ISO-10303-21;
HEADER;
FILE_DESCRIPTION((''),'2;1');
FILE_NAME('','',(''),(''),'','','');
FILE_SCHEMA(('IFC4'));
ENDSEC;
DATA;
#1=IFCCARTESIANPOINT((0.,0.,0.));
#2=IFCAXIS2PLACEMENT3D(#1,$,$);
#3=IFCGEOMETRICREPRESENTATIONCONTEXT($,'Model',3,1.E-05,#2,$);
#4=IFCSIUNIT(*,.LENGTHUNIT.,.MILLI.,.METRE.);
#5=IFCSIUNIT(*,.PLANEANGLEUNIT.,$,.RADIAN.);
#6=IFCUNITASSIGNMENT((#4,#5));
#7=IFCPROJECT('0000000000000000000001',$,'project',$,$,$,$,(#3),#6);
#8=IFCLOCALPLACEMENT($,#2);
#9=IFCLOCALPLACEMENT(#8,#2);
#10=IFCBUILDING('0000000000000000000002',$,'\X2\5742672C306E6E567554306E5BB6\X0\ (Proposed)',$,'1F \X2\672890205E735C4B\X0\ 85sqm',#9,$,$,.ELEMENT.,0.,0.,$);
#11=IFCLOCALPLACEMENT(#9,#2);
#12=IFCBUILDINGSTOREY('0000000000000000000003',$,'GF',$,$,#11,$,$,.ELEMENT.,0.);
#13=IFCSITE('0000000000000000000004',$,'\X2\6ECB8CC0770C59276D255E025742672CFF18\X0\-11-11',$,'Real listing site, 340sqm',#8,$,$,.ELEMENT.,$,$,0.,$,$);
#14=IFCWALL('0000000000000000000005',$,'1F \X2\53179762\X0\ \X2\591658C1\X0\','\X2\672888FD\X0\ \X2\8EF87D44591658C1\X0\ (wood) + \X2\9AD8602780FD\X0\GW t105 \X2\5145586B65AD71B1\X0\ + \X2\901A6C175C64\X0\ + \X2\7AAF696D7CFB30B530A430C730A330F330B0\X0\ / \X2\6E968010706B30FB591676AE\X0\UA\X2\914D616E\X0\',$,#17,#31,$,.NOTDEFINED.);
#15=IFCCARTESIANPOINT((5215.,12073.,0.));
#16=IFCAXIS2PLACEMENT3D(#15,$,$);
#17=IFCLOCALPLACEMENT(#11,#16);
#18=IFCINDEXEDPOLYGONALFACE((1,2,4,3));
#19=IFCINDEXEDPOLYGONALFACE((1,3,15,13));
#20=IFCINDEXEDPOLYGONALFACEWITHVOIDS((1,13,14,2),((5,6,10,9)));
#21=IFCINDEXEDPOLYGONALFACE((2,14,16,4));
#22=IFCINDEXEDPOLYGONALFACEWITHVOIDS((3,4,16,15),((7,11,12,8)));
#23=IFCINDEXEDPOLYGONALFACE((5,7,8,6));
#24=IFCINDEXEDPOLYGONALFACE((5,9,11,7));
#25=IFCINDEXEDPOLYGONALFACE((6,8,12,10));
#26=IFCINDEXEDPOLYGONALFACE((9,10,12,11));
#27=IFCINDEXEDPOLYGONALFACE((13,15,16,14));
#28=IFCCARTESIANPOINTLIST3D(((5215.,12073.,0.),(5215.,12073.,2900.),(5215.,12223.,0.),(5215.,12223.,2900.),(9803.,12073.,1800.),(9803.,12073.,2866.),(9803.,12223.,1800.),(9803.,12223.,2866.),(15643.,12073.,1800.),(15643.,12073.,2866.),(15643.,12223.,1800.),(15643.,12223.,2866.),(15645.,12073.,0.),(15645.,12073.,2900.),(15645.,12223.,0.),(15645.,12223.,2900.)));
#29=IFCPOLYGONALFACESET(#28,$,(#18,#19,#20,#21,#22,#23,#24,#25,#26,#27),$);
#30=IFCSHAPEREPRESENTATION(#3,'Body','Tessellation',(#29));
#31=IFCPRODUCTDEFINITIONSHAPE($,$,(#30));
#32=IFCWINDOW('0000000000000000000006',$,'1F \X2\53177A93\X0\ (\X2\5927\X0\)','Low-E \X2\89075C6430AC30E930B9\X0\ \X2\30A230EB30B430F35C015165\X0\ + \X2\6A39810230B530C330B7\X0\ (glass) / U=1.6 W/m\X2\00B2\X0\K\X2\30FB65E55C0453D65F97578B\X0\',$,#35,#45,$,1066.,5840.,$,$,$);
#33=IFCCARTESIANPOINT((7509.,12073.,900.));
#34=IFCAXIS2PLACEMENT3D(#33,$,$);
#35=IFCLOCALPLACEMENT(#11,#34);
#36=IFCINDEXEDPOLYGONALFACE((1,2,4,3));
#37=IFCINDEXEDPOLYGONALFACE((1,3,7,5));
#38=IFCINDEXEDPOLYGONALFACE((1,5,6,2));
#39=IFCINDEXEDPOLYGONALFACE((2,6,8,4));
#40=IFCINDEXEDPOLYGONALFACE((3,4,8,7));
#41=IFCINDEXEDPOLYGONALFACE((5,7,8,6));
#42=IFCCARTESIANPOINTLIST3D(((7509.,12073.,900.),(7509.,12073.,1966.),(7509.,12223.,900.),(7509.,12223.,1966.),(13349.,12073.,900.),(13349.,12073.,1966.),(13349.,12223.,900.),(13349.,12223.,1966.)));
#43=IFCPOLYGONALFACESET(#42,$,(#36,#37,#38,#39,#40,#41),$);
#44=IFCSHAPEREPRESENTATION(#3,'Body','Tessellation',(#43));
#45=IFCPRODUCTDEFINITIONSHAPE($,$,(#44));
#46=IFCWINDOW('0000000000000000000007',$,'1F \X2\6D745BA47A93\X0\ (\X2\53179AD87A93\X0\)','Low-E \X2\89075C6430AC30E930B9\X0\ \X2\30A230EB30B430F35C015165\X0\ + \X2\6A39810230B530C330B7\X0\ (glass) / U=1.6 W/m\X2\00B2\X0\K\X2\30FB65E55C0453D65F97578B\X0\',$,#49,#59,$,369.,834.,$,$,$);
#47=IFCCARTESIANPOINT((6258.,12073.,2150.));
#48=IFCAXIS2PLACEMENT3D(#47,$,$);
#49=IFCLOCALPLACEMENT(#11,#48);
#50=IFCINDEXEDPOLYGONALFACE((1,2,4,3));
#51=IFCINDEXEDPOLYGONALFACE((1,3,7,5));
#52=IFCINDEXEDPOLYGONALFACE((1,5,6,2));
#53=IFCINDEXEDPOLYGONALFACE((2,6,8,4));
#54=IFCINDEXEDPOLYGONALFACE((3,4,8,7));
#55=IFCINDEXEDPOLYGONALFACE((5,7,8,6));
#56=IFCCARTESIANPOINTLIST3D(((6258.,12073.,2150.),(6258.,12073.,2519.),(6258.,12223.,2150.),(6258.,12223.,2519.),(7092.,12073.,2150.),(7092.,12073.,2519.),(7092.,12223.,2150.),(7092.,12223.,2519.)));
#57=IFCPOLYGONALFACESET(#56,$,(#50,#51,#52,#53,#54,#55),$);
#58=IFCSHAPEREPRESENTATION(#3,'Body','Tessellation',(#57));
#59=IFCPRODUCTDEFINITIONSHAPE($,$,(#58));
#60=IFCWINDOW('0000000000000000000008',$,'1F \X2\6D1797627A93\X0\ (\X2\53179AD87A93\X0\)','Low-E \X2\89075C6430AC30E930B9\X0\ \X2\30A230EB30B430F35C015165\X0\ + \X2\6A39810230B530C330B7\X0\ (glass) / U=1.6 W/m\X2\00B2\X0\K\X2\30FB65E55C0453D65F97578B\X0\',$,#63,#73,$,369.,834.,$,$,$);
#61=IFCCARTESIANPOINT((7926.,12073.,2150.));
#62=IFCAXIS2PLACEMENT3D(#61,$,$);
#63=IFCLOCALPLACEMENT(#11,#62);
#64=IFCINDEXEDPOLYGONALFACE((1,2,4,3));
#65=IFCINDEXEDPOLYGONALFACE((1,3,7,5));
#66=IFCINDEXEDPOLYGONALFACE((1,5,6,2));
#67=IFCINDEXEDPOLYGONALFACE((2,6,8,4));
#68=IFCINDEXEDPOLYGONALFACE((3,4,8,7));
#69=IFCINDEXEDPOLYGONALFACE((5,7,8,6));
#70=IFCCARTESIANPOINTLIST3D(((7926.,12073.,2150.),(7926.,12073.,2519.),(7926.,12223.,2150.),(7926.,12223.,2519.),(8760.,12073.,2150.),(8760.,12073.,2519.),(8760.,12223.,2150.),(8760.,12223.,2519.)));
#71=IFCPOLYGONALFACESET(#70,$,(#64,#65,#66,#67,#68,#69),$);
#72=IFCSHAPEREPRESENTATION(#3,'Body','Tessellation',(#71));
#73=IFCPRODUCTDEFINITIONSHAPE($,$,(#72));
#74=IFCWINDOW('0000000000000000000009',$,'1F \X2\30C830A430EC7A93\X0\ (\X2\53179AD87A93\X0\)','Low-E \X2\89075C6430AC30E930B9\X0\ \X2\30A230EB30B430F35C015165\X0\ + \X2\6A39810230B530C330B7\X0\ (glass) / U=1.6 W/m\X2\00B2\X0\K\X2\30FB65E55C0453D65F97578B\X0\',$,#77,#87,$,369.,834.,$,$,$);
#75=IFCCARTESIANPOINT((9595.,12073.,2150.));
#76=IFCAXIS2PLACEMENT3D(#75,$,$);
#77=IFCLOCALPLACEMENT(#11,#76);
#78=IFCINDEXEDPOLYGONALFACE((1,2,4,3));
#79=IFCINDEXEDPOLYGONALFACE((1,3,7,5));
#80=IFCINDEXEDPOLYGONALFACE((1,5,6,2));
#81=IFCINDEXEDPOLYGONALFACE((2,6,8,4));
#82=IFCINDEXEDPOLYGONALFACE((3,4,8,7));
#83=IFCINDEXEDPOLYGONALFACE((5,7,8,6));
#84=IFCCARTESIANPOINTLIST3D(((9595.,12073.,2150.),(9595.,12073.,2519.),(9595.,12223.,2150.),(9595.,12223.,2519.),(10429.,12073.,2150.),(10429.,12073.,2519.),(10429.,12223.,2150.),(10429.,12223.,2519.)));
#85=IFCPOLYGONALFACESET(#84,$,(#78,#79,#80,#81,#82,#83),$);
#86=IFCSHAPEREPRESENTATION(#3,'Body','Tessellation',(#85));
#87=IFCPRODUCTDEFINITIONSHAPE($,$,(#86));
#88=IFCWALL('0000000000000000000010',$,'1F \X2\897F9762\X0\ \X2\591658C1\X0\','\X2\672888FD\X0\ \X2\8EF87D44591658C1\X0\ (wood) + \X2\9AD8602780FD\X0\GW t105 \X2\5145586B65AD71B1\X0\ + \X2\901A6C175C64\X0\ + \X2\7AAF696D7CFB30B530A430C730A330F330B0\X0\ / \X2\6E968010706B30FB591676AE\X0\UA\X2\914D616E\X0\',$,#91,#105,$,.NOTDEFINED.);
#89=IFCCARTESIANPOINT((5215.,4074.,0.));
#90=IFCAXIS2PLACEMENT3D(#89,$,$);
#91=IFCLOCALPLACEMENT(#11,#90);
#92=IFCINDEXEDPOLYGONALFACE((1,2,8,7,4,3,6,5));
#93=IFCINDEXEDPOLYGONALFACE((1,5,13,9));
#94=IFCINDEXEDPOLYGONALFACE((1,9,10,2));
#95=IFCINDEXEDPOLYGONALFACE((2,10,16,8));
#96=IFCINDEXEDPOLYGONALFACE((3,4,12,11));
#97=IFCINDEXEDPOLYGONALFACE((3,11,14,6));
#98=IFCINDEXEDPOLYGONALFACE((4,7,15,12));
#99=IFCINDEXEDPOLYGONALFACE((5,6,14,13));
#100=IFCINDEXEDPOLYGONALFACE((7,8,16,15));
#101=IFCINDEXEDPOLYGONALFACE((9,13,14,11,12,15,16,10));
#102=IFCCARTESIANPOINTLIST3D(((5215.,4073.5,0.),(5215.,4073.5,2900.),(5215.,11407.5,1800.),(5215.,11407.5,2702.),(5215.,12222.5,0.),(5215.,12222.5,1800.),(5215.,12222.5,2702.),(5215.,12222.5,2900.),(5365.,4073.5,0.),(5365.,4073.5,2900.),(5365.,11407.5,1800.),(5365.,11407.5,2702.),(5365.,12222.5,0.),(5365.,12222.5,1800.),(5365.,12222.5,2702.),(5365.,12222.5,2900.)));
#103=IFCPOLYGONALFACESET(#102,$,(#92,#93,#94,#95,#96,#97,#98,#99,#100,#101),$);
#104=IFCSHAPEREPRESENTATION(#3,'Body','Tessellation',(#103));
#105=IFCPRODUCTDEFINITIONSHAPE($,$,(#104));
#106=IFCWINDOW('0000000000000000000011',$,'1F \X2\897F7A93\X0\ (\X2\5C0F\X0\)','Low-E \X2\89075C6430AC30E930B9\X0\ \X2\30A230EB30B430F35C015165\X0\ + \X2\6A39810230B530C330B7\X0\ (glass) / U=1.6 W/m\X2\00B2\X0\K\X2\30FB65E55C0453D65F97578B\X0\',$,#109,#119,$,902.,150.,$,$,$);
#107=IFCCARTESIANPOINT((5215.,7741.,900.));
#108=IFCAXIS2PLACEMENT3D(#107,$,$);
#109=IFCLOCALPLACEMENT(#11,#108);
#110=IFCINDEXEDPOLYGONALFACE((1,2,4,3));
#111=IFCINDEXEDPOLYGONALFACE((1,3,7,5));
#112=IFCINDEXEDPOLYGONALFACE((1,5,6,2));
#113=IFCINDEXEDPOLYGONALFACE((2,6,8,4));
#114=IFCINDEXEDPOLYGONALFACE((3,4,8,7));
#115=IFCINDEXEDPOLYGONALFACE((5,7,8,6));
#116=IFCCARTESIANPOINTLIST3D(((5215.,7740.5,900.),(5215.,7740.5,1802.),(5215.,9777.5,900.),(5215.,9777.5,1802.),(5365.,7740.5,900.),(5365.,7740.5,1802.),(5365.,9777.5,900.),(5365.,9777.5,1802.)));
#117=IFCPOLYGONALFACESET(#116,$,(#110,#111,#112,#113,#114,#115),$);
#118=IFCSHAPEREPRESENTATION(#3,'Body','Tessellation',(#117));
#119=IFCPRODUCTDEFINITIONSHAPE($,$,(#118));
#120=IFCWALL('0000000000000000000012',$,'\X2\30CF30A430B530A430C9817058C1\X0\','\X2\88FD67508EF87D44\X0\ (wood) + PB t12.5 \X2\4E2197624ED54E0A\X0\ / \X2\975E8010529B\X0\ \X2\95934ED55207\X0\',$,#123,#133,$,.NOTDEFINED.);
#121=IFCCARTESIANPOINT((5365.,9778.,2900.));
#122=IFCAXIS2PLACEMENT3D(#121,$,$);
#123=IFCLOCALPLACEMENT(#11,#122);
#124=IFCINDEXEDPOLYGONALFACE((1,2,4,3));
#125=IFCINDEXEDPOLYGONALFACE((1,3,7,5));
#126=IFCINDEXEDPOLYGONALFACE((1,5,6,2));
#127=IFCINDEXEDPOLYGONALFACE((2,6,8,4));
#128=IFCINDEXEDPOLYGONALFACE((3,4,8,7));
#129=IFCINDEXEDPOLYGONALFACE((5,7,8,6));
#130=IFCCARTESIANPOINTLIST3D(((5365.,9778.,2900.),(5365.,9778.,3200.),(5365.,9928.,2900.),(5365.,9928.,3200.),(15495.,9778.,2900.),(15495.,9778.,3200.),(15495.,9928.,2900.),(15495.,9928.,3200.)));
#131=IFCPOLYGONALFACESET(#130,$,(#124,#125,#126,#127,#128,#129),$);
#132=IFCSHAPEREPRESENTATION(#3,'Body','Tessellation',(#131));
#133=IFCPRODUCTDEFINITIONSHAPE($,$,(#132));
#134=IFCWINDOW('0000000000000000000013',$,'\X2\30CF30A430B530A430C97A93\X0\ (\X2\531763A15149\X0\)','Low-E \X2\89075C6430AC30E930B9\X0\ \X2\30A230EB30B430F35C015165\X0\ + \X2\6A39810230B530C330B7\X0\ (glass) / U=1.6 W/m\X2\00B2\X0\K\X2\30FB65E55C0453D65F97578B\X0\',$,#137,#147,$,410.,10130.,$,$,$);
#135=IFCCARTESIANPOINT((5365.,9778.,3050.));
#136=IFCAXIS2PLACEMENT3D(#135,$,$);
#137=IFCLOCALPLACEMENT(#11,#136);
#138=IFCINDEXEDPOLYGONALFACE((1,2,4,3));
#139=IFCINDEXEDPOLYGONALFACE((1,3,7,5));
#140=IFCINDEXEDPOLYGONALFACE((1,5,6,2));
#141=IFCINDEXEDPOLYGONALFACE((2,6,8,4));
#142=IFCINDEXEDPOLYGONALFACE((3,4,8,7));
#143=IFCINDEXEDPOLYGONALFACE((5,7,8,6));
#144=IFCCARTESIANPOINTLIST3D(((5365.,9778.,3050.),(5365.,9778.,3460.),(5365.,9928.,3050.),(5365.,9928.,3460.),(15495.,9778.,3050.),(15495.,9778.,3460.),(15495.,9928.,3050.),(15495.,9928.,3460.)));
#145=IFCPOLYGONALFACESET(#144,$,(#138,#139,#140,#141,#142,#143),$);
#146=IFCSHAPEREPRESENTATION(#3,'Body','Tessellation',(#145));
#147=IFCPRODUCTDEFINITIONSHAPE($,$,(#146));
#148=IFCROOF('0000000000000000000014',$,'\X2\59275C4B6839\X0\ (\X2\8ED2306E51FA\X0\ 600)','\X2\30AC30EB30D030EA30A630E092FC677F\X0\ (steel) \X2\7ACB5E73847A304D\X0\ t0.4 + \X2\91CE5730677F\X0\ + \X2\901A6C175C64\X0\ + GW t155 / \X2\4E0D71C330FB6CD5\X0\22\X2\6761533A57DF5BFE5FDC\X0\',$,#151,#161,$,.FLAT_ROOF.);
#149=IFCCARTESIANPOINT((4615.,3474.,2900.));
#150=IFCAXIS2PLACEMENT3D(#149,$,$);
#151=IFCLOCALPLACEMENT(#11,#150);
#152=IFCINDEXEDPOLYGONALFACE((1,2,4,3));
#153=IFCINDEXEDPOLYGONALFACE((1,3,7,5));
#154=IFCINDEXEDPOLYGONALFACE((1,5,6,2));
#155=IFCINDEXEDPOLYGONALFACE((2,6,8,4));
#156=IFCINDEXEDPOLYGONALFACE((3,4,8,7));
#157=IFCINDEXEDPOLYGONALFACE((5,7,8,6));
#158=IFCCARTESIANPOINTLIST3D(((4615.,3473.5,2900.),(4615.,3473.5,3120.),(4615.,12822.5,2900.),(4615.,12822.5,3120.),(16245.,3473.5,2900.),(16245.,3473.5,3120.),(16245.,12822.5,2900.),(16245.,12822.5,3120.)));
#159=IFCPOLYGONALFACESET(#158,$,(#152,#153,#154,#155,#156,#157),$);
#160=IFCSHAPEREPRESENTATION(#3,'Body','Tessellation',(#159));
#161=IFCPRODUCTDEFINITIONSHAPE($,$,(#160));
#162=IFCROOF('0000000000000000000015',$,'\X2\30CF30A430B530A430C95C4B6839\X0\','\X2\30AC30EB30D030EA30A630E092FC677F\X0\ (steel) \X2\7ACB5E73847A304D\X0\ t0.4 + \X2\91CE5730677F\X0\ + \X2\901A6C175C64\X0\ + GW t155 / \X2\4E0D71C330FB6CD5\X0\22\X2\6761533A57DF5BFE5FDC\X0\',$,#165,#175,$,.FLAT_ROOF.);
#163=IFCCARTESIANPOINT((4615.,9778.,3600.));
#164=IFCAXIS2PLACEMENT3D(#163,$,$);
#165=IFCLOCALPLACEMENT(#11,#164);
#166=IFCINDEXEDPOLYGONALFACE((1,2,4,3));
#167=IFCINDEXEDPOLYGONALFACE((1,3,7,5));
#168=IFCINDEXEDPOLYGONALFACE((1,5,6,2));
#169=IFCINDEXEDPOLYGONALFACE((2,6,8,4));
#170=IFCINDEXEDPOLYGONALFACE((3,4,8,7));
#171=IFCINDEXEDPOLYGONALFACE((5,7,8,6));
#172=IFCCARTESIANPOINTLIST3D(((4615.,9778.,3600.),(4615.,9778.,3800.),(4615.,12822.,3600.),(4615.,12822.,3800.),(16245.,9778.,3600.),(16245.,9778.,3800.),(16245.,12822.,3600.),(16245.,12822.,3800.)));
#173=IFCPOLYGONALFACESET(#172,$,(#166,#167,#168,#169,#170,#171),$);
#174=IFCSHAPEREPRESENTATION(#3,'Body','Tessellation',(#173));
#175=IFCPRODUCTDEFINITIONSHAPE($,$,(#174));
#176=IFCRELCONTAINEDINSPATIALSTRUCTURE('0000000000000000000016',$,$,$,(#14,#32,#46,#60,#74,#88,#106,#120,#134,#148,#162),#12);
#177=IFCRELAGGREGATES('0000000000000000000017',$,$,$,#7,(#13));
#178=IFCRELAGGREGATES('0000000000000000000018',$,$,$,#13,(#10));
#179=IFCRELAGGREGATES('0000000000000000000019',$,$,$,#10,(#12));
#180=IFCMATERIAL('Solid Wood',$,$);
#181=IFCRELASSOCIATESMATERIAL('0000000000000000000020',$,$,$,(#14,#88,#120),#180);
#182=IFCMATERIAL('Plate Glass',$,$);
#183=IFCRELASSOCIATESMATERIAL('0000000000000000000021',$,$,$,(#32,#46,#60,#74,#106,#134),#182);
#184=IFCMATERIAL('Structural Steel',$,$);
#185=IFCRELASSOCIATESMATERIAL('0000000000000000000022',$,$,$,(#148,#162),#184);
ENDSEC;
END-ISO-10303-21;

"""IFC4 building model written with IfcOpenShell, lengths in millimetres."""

from ifc_helpers import new_model, si_unit, frame, frame_2d, origin, place, context, project, spatial, rectangle, extrude, material, element, fill, save


model = new_model("IFC4")

# Units and contexts
model_context = context("Model", 3, precision=1e-05, world=origin())
ifc_project = project(units=[si_unit("LENGTHUNIT", "METRE", prefix="MILLI"), si_unit("PLANEANGLEUNIT", "RADIAN")], contexts=[model_context])

# Site, building, storey
site_placement = place(None, origin())
site = spatial("IfcSite", under=ifc_project, at=site_placement, Name="滋賀県大津市坂本８-11-11", ObjectType="Real listing site, 340sqm", CompositionType="ELEMENT", RefElevation=0.0)
building_placement = place(site_placement, origin())
building = spatial("IfcBuilding", under=site, at=building_placement, Name="坂本の湖畔の家 (Proposed)", ObjectType="1F 木造平屋 85sqm", CompositionType="ELEMENT", ElevationOfRefHeight=0.0, ElevationOfTerrain=0.0)
storey_placement = place(building_placement, origin())
storey = spatial("IfcBuildingStorey", under=building, at=storey_placement, Name="GF", CompositionType="ELEMENT", Elevation=0.0)

# Shared definitions
ifc_material_1 = material(Name="Solid Wood")

# Shared definitions
ifc_material_2 = material(Name="Plate Glass")

# Wall, openings, windows
wall_1_placement = place(storey_placement, frame((5215.0, 12073.0, 0.0)))
wall_1 = element("IfcWall", 1, at=wall_1_placement, inside=storey, material=ifc_material_1, Name="1F 北面 外壁", Description="木製 軸組外壁 (wood) + 高性能GW t105 充填断熱 + 通気層 + 窯業系サイディング / 準耐火・外皮UA配慮", PredefinedType="NOTDEFINED", context=model_context, shape_type="SweptSolid", body=[
    extrude(rectangle(XDim=10430.0, YDim=150.0, at=frame_2d((5215.0, 75.0))), frame((5215.0, 12073.0, 0.0)), (0.0, 0.0, 1.0), 2900.0),
])
opening_1_placement = place(storey_placement, frame((7509.0, 12073.0, 900.0)))
opening_1 = element("IfcOpeningElement", 2, at=opening_1_placement, cuts=wall_1, PredefinedType="NOTDEFINED", context=model_context, shape_type="SweptSolid", body=[
    extrude(rectangle(XDim=5840.0, YDim=150.0, at=frame_2d((2920.0, 75.0))), frame((7509.0, 12073.0, 900.0)), (0.0, 0.0, 1.0), 1066.0),
])
opening_2_placement = place(storey_placement, frame((6258.0, 12073.0, 2150.0)))
opening_2 = element("IfcOpeningElement", 3, at=opening_2_placement, cuts=wall_1, PredefinedType="NOTDEFINED", context=model_context, shape_type="SweptSolid", body=[
    extrude(rectangle(XDim=834.0, YDim=150.0, at=frame_2d((417.0, 75.0))), frame((6258.0, 12073.0, 2150.0)), (0.0, 0.0, 1.0), 369.0),
])
opening_3_placement = place(storey_placement, frame((7926.0, 12073.0, 2150.0)))
opening_3 = element("IfcOpeningElement", 4, at=opening_3_placement, cuts=wall_1, PredefinedType="NOTDEFINED", context=model_context, shape_type="SweptSolid", body=[
    extrude(rectangle(XDim=834.0, YDim=150.0, at=frame_2d((417.0, 75.0))), frame((7926.0, 12073.0, 2150.0)), (0.0, 0.0, 1.0), 369.0),
])
opening_4_placement = place(storey_placement, frame((9595.0, 12073.0, 2150.0)))
opening_4 = element("IfcOpeningElement", 5, at=opening_4_placement, cuts=wall_1, PredefinedType="NOTDEFINED", context=model_context, shape_type="SweptSolid", body=[
    extrude(rectangle(XDim=834.0, YDim=150.0, at=frame_2d((417.0, 75.0))), frame((9595.0, 12073.0, 2150.0)), (0.0, 0.0, 1.0), 369.0),
])
window_1_placement = place(storey_placement, frame((7509.0, 12073.0, 900.0)))
window_1 = element("IfcWindow", 6, at=window_1_placement, inside=storey, material=ifc_material_2, Name="1F 北窓 (大)", Description="Low-E 複層ガラス アルゴン封入 + 樹脂サッシ (glass) / U=1.6 W/m²K・日射取得型", OverallHeight=1066.0, OverallWidth=5840.0, context=model_context, shape_type="SweptSolid", body=[
    extrude(rectangle(XDim=5840.0, YDim=150.0, at=frame_2d((2920.0, 75.0))), frame((7509.0, 12073.0, 900.0)), (0.0, 0.0, 1.0), 1066.0),
])
fill(opening_1, window_1)
window_2_placement = place(storey_placement, frame((6258.0, 12073.0, 2150.0)))
window_2 = element("IfcWindow", 7, at=window_2_placement, inside=storey, material=ifc_material_2, Name="1F 浴室窓 (北高窓)", Description="Low-E 複層ガラス アルゴン封入 + 樹脂サッシ (glass) / U=1.6 W/m²K・日射取得型", OverallHeight=369.0, OverallWidth=834.0, context=model_context, shape_type="SweptSolid", body=[
    extrude(rectangle(XDim=834.0, YDim=150.0, at=frame_2d((417.0, 75.0))), frame((6258.0, 12073.0, 2150.0)), (0.0, 0.0, 1.0), 369.0),
])
fill(opening_2, window_2)
window_3_placement = place(storey_placement, frame((7926.0, 12073.0, 2150.0)))
window_3 = element("IfcWindow", 8, at=window_3_placement, inside=storey, material=ifc_material_2, Name="1F 洗面窓 (北高窓)", Description="Low-E 複層ガラス アルゴン封入 + 樹脂サッシ (glass) / U=1.6 W/m²K・日射取得型", OverallHeight=369.0, OverallWidth=834.0, context=model_context, shape_type="SweptSolid", body=[
    extrude(rectangle(XDim=834.0, YDim=150.0, at=frame_2d((417.0, 75.0))), frame((7926.0, 12073.0, 2150.0)), (0.0, 0.0, 1.0), 369.0),
])
fill(opening_3, window_3)
window_4_placement = place(storey_placement, frame((9595.0, 12073.0, 2150.0)))
window_4 = element("IfcWindow", 9, at=window_4_placement, inside=storey, material=ifc_material_2, Name="1F トイレ窓 (北高窓)", Description="Low-E 複層ガラス アルゴン封入 + 樹脂サッシ (glass) / U=1.6 W/m²K・日射取得型", OverallHeight=369.0, OverallWidth=834.0, context=model_context, shape_type="SweptSolid", body=[
    extrude(rectangle(XDim=834.0, YDim=150.0, at=frame_2d((417.0, 75.0))), frame((9595.0, 12073.0, 2150.0)), (0.0, 0.0, 1.0), 369.0),
])
fill(opening_4, window_4)

# Wall, opening, window
wall_2_placement = place(storey_placement, frame((5215.0, 4074.0, 0.0)))
wall_2 = element("IfcWall", 10, at=wall_2_placement, inside=storey, material=ifc_material_1, Name="1F 西面 外壁", Description="木製 軸組外壁 (wood) + 高性能GW t105 充填断熱 + 通気層 + 窯業系サイディング / 準耐火・外皮UA配慮", PredefinedType="NOTDEFINED", context=model_context, shape_type="SweptSolid", body=[
    extrude(rectangle(XDim=150.0, YDim=8149.0, at=frame_2d((75.0, 4074.0))), frame((5215.0, 4074.0, 0.0)), (0.0, 0.0, 1.0), 2900.0),
])
opening_5_placement = place(storey_placement, frame((5215.0, 7741.0, 900.0)))
opening_5 = element("IfcOpeningElement", 11, at=opening_5_placement, cuts=wall_2, PredefinedType="NOTDEFINED", context=model_context, shape_type="SweptSolid", body=[
    extrude(rectangle(XDim=150.0, YDim=2037.0, at=frame_2d((75.0, 1018.0))), frame((5215.0, 7741.0, 900.0)), (0.0, 0.0, 1.0), 902.0),
])
window_5_placement = place(storey_placement, frame((5215.0, 7741.0, 900.0)))
window_5 = element("IfcWindow", 12, at=window_5_placement, inside=storey, material=ifc_material_2, Name="1F 西窓 (小)", Description="Low-E 複層ガラス アルゴン封入 + 樹脂サッシ (glass) / U=1.6 W/m²K・日射取得型", OverallHeight=902.0, OverallWidth=150.0, context=model_context, shape_type="SweptSolid", body=[
    extrude(rectangle(XDim=150.0, YDim=2037.0, at=frame_2d((75.0, 1018.0))), frame((5215.0, 7741.0, 900.0)), (0.0, 0.0, 1.0), 902.0),
])
fill(opening_5, window_5)

# Wall, opening, window
wall_3_placement = place(storey_placement, frame((5365.0, 9778.0, 2900.0)))
wall_3 = element("IfcWall", 13, at=wall_3_placement, inside=storey, material=ifc_material_1, Name="ハイサイド腰壁", Description="製材軸組 (wood) + PB t12.5 両面仕上 / 非耐力 間仕切", PredefinedType="NOTDEFINED", context=model_context, shape_type="SweptSolid", body=[
    extrude(rectangle(XDim=10130.0, YDim=150.0, at=frame_2d((5065.0, 75.0))), frame((5365.0, 9778.0, 2900.0)), (0.0, 0.0, 1.0), 700.0),
])
opening_6_placement = place(storey_placement, frame((5365.0, 9778.0, 3050.0)))
opening_6 = element("IfcOpeningElement", 14, at=opening_6_placement, cuts=wall_3, PredefinedType="NOTDEFINED", context=model_context, shape_type="SweptSolid", body=[
    extrude(rectangle(XDim=10130.0, YDim=150.0, at=frame_2d((5065.0, 75.0))), frame((5365.0, 9778.0, 3050.0)), (0.0, 0.0, 1.0), 410.0),
])
window_6_placement = place(storey_placement, frame((5365.0, 9778.0, 3050.0)))
window_6 = element("IfcWindow", 15, at=window_6_placement, inside=storey, material=ifc_material_2, Name="ハイサイド窓 (北採光)", Description="Low-E 複層ガラス アルゴン封入 + 樹脂サッシ (glass) / U=1.6 W/m²K・日射取得型", OverallHeight=410.0, OverallWidth=10130.0, context=model_context, shape_type="SweptSolid", body=[
    extrude(rectangle(XDim=10130.0, YDim=150.0, at=frame_2d((5065.0, 75.0))), frame((5365.0, 9778.0, 3050.0)), (0.0, 0.0, 1.0), 410.0),
])
fill(opening_6, window_6)

# Roofs
ifc_material_3 = material(Name="Structural Steel")
roof_1_placement = place(storey_placement, frame((4615.0, 3474.0, 2900.0)))
element("IfcRoof", 16, at=roof_1_placement, inside=storey, material=ifc_material_3, Name="大屋根 (軒の出 600)", Description="ガルバリウム鋼板 (steel) 立平葺き t0.4 + 野地板 + 通気層 + GW t155 / 不燃・法22条区域対応", PredefinedType="FLAT_ROOF", context=model_context, shape_type="SweptSolid", body=[
    extrude(rectangle(XDim=11630.0, YDim=9349.0, at=frame_2d((5815.0, 4674.0))), frame((4615.0, 3474.0, 2900.0)), (0.0, 0.0, 1.0), 220.0),
])
roof_2_placement = place(storey_placement, frame((4615.0, 9778.0, 3600.0)))
element("IfcRoof", 17, at=roof_2_placement, inside=storey, material=ifc_material_3, Name="ハイサイド屋根", Description="ガルバリウム鋼板 (steel) 立平葺き t0.4 + 野地板 + 通気層 + GW t155 / 不燃・法22条区域対応", PredefinedType="FLAT_ROOF", context=model_context, shape_type="SweptSolid", body=[
    extrude(rectangle(XDim=11630.0, YDim=3044.0, at=frame_2d((5815.0, 1522.0))), frame((4615.0, 9778.0, 3600.0)), (0.0, 0.0, 1.0), 200.0),
])

save(model, "model.ifc")
